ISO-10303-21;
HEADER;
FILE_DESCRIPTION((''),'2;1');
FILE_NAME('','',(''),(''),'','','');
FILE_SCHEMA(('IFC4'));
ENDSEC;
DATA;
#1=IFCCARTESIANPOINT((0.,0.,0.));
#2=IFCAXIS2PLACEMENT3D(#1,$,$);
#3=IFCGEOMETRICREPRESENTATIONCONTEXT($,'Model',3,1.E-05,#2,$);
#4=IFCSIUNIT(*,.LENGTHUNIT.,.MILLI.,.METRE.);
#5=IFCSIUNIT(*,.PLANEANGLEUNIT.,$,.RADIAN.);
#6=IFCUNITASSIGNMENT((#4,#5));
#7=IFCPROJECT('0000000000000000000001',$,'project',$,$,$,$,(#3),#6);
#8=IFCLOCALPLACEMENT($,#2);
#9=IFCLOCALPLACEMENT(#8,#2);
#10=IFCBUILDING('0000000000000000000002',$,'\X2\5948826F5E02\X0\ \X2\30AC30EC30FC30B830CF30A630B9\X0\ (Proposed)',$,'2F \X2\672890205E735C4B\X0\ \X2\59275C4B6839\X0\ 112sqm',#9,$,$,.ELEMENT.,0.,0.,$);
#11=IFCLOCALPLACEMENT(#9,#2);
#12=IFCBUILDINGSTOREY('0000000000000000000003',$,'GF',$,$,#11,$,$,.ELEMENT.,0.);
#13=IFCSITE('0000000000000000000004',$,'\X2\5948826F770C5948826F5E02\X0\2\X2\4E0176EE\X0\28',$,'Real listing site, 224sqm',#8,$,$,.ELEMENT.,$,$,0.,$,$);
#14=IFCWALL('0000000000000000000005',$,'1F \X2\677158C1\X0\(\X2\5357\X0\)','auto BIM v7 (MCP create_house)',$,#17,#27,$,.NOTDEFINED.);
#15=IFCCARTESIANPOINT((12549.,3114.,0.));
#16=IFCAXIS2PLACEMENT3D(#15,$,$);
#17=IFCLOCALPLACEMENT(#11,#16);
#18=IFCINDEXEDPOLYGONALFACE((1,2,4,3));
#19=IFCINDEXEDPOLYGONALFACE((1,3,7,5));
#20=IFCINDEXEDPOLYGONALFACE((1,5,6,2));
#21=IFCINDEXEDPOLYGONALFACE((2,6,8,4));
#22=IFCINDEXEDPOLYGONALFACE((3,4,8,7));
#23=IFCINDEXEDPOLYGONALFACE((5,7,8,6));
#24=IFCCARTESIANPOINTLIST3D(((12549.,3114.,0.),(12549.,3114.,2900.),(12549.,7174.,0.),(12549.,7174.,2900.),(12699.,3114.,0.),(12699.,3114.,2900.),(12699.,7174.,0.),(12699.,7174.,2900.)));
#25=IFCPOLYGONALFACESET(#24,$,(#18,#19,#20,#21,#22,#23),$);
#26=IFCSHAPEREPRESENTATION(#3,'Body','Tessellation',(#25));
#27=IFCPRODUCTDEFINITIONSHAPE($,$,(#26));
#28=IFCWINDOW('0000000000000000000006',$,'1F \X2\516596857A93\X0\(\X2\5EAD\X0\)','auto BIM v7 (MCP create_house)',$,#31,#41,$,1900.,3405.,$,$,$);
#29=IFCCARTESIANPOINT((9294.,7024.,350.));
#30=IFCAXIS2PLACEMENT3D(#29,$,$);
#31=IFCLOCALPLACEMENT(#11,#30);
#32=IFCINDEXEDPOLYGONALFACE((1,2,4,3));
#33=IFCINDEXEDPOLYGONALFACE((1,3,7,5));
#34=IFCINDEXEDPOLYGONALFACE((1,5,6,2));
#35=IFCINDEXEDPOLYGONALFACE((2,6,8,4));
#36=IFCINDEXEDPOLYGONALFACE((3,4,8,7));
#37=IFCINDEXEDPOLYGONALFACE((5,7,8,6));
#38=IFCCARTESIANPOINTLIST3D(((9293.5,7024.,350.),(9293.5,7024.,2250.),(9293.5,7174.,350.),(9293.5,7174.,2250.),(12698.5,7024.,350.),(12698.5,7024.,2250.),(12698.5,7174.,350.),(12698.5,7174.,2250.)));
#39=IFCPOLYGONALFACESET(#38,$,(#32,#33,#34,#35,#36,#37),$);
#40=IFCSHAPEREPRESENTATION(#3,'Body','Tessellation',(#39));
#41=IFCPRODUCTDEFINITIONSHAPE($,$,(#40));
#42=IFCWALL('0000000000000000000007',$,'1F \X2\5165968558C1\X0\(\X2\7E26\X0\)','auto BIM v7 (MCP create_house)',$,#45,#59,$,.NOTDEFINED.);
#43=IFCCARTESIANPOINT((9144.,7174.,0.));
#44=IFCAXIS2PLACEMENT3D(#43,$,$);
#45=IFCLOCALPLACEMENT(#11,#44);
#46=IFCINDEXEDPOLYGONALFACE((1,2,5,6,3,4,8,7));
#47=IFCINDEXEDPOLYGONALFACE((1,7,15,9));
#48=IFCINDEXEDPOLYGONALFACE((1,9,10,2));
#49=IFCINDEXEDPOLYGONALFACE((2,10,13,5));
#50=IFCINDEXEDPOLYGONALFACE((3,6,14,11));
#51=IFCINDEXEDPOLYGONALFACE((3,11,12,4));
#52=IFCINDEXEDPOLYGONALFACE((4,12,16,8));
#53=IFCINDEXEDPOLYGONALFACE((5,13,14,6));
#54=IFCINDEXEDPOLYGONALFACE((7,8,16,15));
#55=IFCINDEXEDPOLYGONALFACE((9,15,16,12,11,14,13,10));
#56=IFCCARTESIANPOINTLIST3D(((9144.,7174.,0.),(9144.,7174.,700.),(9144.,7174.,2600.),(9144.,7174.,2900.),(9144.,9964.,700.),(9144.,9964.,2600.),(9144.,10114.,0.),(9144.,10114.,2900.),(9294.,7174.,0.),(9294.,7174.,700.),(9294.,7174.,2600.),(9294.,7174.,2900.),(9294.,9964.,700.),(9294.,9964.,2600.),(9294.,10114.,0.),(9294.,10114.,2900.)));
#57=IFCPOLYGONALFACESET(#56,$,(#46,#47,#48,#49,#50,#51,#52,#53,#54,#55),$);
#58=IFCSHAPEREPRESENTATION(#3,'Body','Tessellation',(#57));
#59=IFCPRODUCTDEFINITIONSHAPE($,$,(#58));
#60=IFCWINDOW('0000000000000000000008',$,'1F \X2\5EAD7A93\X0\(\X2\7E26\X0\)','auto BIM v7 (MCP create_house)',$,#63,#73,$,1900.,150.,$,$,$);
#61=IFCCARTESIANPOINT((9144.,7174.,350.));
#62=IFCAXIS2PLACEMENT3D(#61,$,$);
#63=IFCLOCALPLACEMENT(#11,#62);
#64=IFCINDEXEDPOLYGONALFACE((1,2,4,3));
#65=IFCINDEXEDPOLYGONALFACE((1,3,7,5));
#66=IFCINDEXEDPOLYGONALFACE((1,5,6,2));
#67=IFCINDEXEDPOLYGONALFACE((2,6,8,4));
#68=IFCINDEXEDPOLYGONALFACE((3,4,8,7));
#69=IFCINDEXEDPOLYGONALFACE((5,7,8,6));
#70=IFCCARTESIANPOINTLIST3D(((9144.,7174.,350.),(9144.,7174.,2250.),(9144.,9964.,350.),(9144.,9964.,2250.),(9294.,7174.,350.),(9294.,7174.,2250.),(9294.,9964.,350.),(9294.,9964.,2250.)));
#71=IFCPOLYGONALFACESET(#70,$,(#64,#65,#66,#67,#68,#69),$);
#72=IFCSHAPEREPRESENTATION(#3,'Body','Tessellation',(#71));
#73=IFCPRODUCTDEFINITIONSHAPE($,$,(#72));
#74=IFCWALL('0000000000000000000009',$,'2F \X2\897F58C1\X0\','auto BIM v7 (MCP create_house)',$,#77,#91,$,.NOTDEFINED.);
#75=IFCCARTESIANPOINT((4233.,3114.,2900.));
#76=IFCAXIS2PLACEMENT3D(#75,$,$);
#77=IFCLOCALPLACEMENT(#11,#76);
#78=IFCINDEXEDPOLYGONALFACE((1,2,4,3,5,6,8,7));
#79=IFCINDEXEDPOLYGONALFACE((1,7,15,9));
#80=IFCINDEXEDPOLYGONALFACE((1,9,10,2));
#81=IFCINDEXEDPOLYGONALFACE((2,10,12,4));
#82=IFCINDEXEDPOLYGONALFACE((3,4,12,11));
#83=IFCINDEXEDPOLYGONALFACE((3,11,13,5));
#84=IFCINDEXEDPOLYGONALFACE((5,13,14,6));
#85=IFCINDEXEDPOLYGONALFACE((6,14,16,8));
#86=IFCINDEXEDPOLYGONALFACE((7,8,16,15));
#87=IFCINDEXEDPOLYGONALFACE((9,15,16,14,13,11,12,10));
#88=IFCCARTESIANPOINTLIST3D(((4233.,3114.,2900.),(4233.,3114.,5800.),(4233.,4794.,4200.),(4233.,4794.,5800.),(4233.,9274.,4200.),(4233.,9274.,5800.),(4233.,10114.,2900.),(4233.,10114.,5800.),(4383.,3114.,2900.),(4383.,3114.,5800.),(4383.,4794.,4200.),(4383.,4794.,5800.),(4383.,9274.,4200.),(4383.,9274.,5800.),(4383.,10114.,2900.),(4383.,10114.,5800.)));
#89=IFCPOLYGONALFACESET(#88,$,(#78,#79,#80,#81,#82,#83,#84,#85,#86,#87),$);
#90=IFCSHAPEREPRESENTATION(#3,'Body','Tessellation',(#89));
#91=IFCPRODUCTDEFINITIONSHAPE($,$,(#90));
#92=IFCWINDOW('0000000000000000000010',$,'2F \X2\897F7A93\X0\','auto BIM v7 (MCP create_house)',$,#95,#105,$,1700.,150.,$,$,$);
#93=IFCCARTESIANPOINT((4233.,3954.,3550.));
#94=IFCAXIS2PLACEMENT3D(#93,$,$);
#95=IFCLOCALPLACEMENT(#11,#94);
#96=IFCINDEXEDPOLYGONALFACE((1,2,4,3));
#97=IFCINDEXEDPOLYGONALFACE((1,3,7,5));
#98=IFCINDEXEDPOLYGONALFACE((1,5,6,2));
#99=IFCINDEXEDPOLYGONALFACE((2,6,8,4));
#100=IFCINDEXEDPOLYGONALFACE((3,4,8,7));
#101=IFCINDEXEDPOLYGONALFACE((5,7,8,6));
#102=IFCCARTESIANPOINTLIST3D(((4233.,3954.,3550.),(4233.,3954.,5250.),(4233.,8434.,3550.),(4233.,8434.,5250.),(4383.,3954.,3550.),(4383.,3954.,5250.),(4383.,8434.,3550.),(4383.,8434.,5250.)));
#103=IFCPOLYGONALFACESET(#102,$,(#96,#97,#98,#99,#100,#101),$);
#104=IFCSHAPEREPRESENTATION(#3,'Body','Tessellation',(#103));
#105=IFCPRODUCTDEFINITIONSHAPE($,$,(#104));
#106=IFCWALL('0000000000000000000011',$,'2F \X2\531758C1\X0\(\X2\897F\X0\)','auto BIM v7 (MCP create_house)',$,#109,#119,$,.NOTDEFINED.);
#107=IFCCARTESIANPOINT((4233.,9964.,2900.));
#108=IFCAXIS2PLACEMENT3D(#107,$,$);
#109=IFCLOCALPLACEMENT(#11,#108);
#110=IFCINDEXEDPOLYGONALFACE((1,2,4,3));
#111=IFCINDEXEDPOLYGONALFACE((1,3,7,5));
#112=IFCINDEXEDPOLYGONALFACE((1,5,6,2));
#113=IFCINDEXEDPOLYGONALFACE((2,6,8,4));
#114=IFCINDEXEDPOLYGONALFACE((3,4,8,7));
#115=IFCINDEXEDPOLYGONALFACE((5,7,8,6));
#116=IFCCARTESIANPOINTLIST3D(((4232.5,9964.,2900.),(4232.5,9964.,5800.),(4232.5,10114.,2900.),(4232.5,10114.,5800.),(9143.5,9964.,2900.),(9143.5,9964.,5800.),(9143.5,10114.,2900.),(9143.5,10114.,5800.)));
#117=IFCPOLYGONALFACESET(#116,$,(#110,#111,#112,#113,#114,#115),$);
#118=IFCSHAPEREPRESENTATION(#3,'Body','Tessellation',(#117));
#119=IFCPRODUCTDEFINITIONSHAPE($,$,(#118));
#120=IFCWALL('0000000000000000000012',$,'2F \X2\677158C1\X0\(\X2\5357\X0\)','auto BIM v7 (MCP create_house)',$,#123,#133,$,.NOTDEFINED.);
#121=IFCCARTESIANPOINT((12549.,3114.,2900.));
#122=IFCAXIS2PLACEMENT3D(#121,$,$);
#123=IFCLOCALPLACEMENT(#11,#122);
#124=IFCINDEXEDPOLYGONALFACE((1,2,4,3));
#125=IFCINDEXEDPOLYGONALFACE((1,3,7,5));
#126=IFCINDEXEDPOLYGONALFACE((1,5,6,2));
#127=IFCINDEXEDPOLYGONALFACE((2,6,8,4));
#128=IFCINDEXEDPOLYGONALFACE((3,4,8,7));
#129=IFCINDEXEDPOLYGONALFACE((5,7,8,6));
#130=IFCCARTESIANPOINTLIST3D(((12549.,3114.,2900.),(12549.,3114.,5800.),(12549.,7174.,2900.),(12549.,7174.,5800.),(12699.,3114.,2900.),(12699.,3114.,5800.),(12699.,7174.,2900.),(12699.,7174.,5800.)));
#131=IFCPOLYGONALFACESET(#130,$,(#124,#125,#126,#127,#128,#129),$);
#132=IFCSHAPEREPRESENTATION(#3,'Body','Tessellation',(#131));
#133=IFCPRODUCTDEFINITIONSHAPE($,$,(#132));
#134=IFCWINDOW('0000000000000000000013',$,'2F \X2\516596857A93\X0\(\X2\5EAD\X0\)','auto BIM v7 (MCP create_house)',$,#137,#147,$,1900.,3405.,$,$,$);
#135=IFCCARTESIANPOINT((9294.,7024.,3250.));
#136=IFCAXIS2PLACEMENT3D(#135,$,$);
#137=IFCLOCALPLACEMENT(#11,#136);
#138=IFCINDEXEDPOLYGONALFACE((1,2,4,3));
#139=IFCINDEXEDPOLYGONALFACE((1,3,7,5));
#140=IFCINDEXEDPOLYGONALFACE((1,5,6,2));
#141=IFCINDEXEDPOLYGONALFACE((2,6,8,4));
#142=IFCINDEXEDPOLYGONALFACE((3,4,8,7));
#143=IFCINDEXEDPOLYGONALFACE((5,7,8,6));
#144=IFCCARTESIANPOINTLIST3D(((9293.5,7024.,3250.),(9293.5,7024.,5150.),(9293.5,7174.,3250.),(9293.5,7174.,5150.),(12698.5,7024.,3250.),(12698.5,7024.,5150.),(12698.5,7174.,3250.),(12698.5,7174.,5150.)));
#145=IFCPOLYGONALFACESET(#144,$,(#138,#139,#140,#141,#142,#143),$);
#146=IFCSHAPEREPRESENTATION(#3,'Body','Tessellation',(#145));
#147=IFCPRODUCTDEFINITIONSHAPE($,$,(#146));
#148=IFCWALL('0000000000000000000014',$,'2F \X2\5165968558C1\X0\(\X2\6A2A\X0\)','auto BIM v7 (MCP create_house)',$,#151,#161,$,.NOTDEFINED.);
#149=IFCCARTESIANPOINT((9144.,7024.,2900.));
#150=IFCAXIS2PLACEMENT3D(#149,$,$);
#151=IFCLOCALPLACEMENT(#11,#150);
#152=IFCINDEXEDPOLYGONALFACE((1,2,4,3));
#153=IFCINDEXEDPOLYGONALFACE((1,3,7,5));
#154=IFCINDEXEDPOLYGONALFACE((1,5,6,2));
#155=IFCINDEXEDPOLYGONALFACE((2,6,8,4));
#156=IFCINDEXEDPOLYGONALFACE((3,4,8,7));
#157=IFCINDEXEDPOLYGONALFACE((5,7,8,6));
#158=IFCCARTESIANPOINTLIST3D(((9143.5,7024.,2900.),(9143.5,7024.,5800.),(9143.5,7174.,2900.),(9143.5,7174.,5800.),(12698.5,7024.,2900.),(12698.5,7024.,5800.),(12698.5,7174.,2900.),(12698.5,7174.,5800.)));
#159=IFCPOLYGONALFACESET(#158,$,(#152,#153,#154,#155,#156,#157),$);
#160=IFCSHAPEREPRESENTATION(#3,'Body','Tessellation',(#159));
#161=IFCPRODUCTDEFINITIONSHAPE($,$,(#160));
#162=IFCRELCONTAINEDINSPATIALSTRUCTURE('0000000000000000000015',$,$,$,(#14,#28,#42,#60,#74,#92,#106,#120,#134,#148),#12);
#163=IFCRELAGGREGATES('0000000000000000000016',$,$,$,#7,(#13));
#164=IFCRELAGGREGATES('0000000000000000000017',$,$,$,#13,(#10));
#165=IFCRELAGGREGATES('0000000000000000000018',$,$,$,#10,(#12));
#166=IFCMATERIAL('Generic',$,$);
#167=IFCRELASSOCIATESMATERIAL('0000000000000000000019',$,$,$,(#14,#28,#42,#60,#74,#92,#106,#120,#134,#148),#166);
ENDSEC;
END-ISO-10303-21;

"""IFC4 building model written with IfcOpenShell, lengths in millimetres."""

from ifc_helpers import new_model, si_unit, frame, frame_2d, origin, place, context, project, spatial, rectangle, extrude, material, element, fill, save


model = new_model("IFC4")

# Units and contexts
model_context = context("Model", 3, precision=1e-05, world=origin())
ifc_project = project(units=[si_unit("LENGTHUNIT", "METRE", prefix="MILLI"), si_unit("PLANEANGLEUNIT", "RADIAN")], contexts=[model_context])

# Site, building, storey
site_placement = place(None, origin())
site = spatial("IfcSite", under=ifc_project, at=site_placement, Name="奈良県奈良市2丁目28", ObjectType="Real listing site, 224sqm", CompositionType="ELEMENT", RefElevation=0.0)
building_placement = place(site_placement, origin())
building = spatial("IfcBuilding", under=site, at=building_placement, Name="奈良市 ガレージハウス (Proposed)", ObjectType="2F 木造平屋 大屋根 112sqm", CompositionType="ELEMENT", ElevationOfRefHeight=0.0, ElevationOfTerrain=0.0)
storey_placement = place(building_placement, origin())
storey = spatial("IfcBuildingStorey", under=building, at=storey_placement, Name="GF", CompositionType="ELEMENT", Elevation=0.0)

# Shared definitions
ifc_material = material(Name="Generic")

# Wall, opening, window
wall_1_placement = place(storey_placement, frame((12549.0, 3114.0, 0.0)))
wall_1 = element("IfcWall", 1, at=wall_1_placement, inside=storey, material=ifc_material, Name="1F 東壁(南)", Description="auto BIM v7 (MCP create_house)", PredefinedType="NOTDEFINED", context=model_context, shape_type="SweptSolid", body=[
    extrude(rectangle(XDim=150.0, YDim=4060.0, at=frame_2d((75.0, 2030.0))), frame((12549.0, 3114.0, 0.0)), (0.0, 0.0, 1.0), 2900.0),
])
opening_1_placement = place(storey_placement, frame((9294.0, 7024.0, 350.0)))
opening_1 = element("IfcOpeningElement", 2, at=opening_1_placement, cuts=wall_1, PredefinedType="NOTDEFINED", context=model_context, shape_type="SweptSolid", body=[
    extrude(rectangle(XDim=3405.0, YDim=150.0, at=frame_2d((1702.0, 75.0))), frame((9294.0, 7024.0, 350.0)), (0.0, 0.0, 1.0), 1900.0),
])
window_1_placement = place(storey_placement, frame((9294.0, 7024.0, 350.0)))
window_1 = element("IfcWindow", 3, at=window_1_placement, inside=storey, material=ifc_material, Name="1F 入隅窓(庭)", Description="auto BIM v7 (MCP create_house)", OverallHeight=1900.0, OverallWidth=3405.0, context=model_context, shape_type="SweptSolid", body=[
    extrude(rectangle(XDim=3405.0, YDim=150.0, at=frame_2d((1702.0, 75.0))), frame((9294.0, 7024.0, 350.0)), (0.0, 0.0, 1.0), 1900.0),
])
fill(opening_1, window_1)

# Wall, opening, window
wall_2_placement = place(storey_placement, frame((9144.0, 7174.0, 0.0)))
wall_2 = element("IfcWall", 4, at=wall_2_placement, inside=storey, material=ifc_material, Name="1F 入隅壁(縦)", Description="auto BIM v7 (MCP create_house)", PredefinedType="NOTDEFINED", context=model_context, shape_type="SweptSolid", body=[
    extrude(rectangle(XDim=150.0, YDim=2940.0, at=frame_2d((75.0, 1470.0))), frame((9144.0, 7174.0, 0.0)), (0.0, 0.0, 1.0), 2900.0),
])
opening_2_placement = place(storey_placement, frame((9144.0, 7174.0, 350.0)))
opening_2 = element("IfcOpeningElement", 5, at=opening_2_placement, cuts=wall_2, PredefinedType="NOTDEFINED", context=model_context, shape_type="SweptSolid", body=[
    extrude(rectangle(XDim=150.0, YDim=2790.0, at=frame_2d((75.0, 1395.0))), frame((9144.0, 7174.0, 350.0)), (0.0, 0.0, 1.0), 1900.0),
])
window_2_placement = place(storey_placement, frame((9144.0, 7174.0, 350.0)))
window_2 = element("IfcWindow", 6, at=window_2_placement, inside=storey, material=ifc_material, Name="1F 庭窓(縦)", Description="auto BIM v7 (MCP create_house)", OverallHeight=1900.0, OverallWidth=150.0, context=model_context, shape_type="SweptSolid", body=[
    extrude(rectangle(XDim=150.0, YDim=2790.0, at=frame_2d((75.0, 1395.0))), frame((9144.0, 7174.0, 350.0)), (0.0, 0.0, 1.0), 1900.0),
])
fill(opening_2, window_2)

# Wall, opening, window
wall_3_placement = place(storey_placement, frame((4233.0, 3114.0, 2900.0)))
wall_3 = element("IfcWall", 7, at=wall_3_placement, inside=storey, material=ifc_material, Name="2F 西壁", Description="auto BIM v7 (MCP create_house)", PredefinedType="NOTDEFINED", context=model_context, shape_type="SweptSolid", body=[
    extrude(rectangle(XDim=150.0, YDim=7000.0, at=frame_2d((75.0, 3500.0))), frame((4233.0, 3114.0, 2900.0)), (0.0, 0.0, 1.0), 2900.0),
])
opening_3_placement = place(storey_placement, frame((4233.0, 3954.0, 3550.0)))
opening_3 = element("IfcOpeningElement", 8, at=opening_3_placement, cuts=wall_3, PredefinedType="NOTDEFINED", context=model_context, shape_type="SweptSolid", body=[
    extrude(rectangle(XDim=150.0, YDim=4480.0, at=frame_2d((75.0, 2240.0))), frame((4233.0, 3954.0, 3550.0)), (0.0, 0.0, 1.0), 1700.0),
])
window_3_placement = place(storey_placement, frame((4233.0, 3954.0, 3550.0)))
window_3 = element("IfcWindow", 9, at=window_3_placement, inside=storey, material=ifc_material, Name="2F 西窓", Description="auto BIM v7 (MCP create_house)", OverallHeight=1700.0, OverallWidth=150.0, context=model_context, shape_type="SweptSolid", body=[
    extrude(rectangle(XDim=150.0, YDim=4480.0, at=frame_2d((75.0, 2240.0))), frame((4233.0, 3954.0, 3550.0)), (0.0, 0.0, 1.0), 1700.0),
])
fill(opening_3, window_3)

# Wall
wall_4_placement = place(storey_placement, frame((4233.0, 9964.0, 2900.0)))
element("IfcWall", 10, at=wall_4_placement, inside=storey, material=ifc_material, Name="2F 北壁(西)", Description="auto BIM v7 (MCP create_house)", PredefinedType="NOTDEFINED", context=model_context, shape_type="SweptSolid", body=[
    extrude(rectangle(XDim=4911.0, YDim=150.0, at=frame_2d((2455.0, 75.0))), frame((4233.0, 9964.0, 2900.0)), (0.0, 0.0, 1.0), 2900.0),
])

# Wall, opening, window
wall_5_placement = place(storey_placement, frame((12549.0, 3114.0, 2900.0)))
wall_5 = element("IfcWall", 11, at=wall_5_placement, inside=storey, material=ifc_material, Name="2F 東壁(南)", Description="auto BIM v7 (MCP create_house)", PredefinedType="NOTDEFINED", context=model_context, shape_type="SweptSolid", body=[
    extrude(rectangle(XDim=150.0, YDim=4060.0, at=frame_2d((75.0, 2030.0))), frame((12549.0, 3114.0, 2900.0)), (0.0, 0.0, 1.0), 2900.0),
])
opening_4_placement = place(storey_placement, frame((9294.0, 7024.0, 3250.0)))
opening_4 = element("IfcOpeningElement", 12, at=opening_4_placement, cuts=wall_5, PredefinedType="NOTDEFINED", context=model_context, shape_type="SweptSolid", body=[
    extrude(rectangle(XDim=3405.0, YDim=150.0, at=frame_2d((1702.0, 75.0))), frame((9294.0, 7024.0, 3250.0)), (0.0, 0.0, 1.0), 1900.0),
])
window_4_placement = place(storey_placement, frame((9294.0, 7024.0, 3250.0)))
window_4 = element("IfcWindow", 13, at=window_4_placement, inside=storey, material=ifc_material, Name="2F 入隅窓(庭)", Description="auto BIM v7 (MCP create_house)", OverallHeight=1900.0, OverallWidth=3405.0, context=model_context, shape_type="SweptSolid", body=[
    extrude(rectangle(XDim=3405.0, YDim=150.0, at=frame_2d((1702.0, 75.0))), frame((9294.0, 7024.0, 3250.0)), (0.0, 0.0, 1.0), 1900.0),
])
fill(opening_4, window_4)

# Wall
wall_6_placement = place(storey_placement, frame((9144.0, 7024.0, 2900.0)))
element("IfcWall", 14, at=wall_6_placement, inside=storey, material=ifc_material, Name="2F 入隅壁(横)", Description="auto BIM v7 (MCP create_house)", PredefinedType="NOTDEFINED", context=model_context, shape_type="SweptSolid", body=[
    extrude(rectangle(XDim=3555.0, YDim=150.0, at=frame_2d((1777.0, 75.0))), frame((9144.0, 7024.0, 2900.0)), (0.0, 0.0, 1.0), 2900.0),
])

save(model, "model.ifc")
